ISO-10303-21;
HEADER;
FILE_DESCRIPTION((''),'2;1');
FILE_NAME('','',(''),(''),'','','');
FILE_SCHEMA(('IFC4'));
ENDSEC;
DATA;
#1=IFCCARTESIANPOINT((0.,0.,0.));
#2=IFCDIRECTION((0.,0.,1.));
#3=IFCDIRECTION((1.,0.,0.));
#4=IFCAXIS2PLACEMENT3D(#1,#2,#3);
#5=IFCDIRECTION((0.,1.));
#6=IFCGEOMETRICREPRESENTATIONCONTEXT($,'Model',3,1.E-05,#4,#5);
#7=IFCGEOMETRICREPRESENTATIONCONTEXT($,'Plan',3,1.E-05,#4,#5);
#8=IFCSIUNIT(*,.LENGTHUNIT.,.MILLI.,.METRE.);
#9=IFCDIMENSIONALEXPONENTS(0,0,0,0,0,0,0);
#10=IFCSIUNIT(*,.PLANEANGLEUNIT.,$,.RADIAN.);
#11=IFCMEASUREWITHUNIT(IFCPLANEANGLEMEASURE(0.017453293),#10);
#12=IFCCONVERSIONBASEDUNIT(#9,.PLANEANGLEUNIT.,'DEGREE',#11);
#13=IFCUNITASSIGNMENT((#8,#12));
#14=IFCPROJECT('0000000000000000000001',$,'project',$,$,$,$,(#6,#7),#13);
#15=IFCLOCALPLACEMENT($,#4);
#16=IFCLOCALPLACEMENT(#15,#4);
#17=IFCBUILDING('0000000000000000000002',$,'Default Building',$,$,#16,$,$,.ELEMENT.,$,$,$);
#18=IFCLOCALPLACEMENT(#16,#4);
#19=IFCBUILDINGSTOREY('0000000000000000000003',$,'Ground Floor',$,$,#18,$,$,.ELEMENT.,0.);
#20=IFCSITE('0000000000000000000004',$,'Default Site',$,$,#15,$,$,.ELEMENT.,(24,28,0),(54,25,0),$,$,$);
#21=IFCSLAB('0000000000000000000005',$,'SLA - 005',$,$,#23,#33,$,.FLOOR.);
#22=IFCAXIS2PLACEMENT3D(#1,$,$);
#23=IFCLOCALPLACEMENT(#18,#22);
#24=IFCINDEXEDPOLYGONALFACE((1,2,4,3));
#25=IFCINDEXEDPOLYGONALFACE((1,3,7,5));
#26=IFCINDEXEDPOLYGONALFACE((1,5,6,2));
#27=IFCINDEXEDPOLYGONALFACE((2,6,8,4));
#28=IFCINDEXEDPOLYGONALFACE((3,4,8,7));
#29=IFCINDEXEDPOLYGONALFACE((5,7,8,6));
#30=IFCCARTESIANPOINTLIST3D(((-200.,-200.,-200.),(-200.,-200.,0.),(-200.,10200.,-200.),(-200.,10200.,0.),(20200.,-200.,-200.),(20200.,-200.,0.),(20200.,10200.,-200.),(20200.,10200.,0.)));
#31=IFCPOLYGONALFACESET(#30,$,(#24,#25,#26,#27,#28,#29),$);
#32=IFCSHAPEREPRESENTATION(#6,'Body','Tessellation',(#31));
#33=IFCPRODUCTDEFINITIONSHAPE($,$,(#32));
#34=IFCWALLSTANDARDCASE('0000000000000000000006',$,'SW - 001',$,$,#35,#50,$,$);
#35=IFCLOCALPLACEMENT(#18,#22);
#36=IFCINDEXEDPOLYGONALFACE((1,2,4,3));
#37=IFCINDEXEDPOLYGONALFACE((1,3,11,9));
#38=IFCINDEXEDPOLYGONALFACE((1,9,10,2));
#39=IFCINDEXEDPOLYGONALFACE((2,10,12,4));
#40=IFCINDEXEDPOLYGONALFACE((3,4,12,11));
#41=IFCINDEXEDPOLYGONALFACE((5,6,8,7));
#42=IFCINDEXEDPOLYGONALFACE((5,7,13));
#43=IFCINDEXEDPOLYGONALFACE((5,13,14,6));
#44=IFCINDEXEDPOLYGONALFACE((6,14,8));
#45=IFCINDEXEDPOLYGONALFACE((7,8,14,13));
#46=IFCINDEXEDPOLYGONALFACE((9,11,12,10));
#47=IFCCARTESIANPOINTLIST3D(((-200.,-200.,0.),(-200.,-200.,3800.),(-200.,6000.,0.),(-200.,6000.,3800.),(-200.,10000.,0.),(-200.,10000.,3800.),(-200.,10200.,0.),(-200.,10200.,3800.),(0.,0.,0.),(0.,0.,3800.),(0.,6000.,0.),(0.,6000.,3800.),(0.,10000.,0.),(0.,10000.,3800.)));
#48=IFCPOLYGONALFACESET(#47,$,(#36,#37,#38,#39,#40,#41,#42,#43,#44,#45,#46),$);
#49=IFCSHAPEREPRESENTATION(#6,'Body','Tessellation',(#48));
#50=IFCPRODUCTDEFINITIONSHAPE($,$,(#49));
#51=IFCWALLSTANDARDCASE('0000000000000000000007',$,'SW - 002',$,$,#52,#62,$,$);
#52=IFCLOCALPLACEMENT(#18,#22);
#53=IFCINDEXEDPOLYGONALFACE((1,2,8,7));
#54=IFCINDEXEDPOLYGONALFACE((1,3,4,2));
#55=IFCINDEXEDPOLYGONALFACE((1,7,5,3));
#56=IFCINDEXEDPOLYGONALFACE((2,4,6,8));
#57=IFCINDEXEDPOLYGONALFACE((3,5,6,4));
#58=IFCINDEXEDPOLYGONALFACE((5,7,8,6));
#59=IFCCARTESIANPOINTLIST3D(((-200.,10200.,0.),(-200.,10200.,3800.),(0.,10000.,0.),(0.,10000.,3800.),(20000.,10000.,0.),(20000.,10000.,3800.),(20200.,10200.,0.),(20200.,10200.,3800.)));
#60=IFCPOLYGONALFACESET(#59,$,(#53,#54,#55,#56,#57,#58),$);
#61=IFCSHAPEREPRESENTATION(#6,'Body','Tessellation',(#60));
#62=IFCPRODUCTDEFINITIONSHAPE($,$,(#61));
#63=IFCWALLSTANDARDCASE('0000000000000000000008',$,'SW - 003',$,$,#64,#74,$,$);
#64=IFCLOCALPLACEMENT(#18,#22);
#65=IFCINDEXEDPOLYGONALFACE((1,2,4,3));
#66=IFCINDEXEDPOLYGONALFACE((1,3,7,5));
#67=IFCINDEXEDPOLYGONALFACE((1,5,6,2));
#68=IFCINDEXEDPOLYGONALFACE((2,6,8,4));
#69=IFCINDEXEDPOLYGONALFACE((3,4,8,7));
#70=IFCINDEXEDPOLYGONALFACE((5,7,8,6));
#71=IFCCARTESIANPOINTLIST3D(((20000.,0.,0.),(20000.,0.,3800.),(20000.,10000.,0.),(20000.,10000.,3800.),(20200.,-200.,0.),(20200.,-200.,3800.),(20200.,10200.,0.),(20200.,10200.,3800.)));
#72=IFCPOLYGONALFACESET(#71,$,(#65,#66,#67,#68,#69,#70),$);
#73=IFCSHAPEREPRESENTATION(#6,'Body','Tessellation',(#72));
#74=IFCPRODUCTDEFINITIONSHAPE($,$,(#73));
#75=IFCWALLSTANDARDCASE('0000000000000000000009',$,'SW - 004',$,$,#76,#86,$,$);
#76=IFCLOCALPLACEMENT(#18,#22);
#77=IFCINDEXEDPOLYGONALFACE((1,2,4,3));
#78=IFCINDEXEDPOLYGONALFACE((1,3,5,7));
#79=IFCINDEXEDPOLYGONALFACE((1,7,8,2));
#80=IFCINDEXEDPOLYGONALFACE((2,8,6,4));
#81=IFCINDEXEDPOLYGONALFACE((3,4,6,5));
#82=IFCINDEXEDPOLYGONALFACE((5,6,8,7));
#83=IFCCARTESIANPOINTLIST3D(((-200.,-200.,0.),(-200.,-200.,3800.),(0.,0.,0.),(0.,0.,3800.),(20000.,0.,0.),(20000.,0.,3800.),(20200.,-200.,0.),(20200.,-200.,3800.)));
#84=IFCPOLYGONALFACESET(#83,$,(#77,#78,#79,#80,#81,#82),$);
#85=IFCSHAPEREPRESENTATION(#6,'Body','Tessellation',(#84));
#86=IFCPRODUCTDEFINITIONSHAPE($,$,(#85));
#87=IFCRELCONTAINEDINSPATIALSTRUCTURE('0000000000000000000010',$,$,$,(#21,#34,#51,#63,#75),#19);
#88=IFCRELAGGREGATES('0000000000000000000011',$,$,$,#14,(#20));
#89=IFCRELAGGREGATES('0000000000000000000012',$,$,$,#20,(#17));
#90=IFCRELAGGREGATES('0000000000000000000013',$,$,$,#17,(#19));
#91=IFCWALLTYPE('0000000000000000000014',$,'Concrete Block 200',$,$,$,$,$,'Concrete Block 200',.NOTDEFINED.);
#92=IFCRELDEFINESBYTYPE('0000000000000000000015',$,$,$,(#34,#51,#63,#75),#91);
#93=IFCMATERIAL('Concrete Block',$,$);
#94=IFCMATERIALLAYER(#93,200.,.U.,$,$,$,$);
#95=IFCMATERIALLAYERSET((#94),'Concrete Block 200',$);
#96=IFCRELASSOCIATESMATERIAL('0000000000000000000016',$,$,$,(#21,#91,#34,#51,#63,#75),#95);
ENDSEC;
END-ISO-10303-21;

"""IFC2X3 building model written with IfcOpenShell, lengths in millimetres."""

from ifc_helpers import new_model, entity, si_unit, converted_unit, direction, frame, origin_with_axes, place, context, project, spatial, polyline, outline, extrude, material, layer, layer_set, layer_usage, type_object, element, save


model = new_model("IFC2X3")

# Units and contexts
model_context = context("Model", 3, precision=1e-05, world=origin_with_axes(), true_north=direction((0.0, 1.0)))
plan_context = context("Plan", 3, precision=1e-05, world=origin_with_axes(), true_north=direction((0.0, 1.0)))
ifc_project = project(units=[si_unit("LENGTHUNIT", "METRE", prefix="MILLI"), converted_unit("PLANEANGLEUNIT", "DEGREE", entity("IfcPlaneAngleMeasure", 0.017453293), si_unit("PLANEANGLEUNIT", "RADIAN"), dimensions=[0, 0, 0, 0, 0, 0, 0])], contexts=[model_context, plan_context])

# Site, building, storey
site_placement = place(None, origin_with_axes())
site = spatial("IfcSite", under=ifc_project, at=site_placement, Name="Default Site", CompositionType="ELEMENT", RefLatitude=(24, 28, 0), RefLongitude=(54, 25, 0))
building_placement = place(site_placement, origin_with_axes())
building = spatial("IfcBuilding", under=site, at=building_placement, Name="Default Building", CompositionType="ELEMENT")
storey_placement = place(building_placement, origin_with_axes())
storey = spatial("IfcBuildingStorey", under=building, at=storey_placement, Name="Ground Floor", CompositionType="ELEMENT", Elevation=0.0)

# Slab
ifc_material = material(Name="Concrete Block")
ifc_layer = layer(ifc_material, 200.0, ventilated="UNKNOWN")
ifc_layer_set = layer_set([ifc_layer], Name="Concrete Block 200")
ifc_layer_usage_1 = layer_usage(ifc_layer_set, "AXIS3", "NEGATIVE", 200.0)
slab_placement = place(storey_placement, frame((-200.0, 10200.0, -200.0), z_axis=(0.0, 0.0, 1.0), x_axis=(1.0, 0.0, 0.0)))
element("IfcSlab", 1, at=slab_placement, inside=storey, material=ifc_layer_usage_1, Name="SLA - 005", PredefinedType="FLOOR", context=model_context, shape_type="SweptSolid", body=[
    extrude(outline(polyline([(0.0, 0.0), (20400.0, 0.0), (20400.0, -10400.0), (0.0, -10400.0), (0.0, 0.0)])), origin_with_axes(), (0.0, 0.0, 1.0), 200.0),
])

# Wall, opening
ifc_layer_usage_2 = layer_usage(ifc_layer_set, "AXIS2", "POSITIVE", 0.0)
wall_type = type_object("IfcWallType", Name="Concrete Block 200", ElementType="Concrete Block 200", PredefinedType="NOTDEFINED", material=ifc_layer_set)
wall_1_placement = place(storey_placement, frame((0.0, 0.0, 0.0), z_axis=(0.0, 0.0, 1.0), x_axis=(0.0, 1.0, 0.0)))
wall_1 = element("IfcWallStandardCase", 2, at=wall_1_placement, inside=storey, type_object=wall_type, material=ifc_layer_usage_2, Name="SW - 001", context=model_context, shape_type="SweptSolid", body=[
    extrude(outline(polyline([(0.0, 0.0), (10000.0, 0.0), (10200.0, 200.0), (-200.0, 200.0), (0.0, 0.0)])), origin_with_axes(), (0.0, 0.0, 1.0), 3800.0),
])
opening_placement = place(wall_1_placement, frame((8000.0, 0.0, 0.0), z_axis=(0.0, 0.0, 1.0), x_axis=(1.0, 0.0, 0.0)))
element("IfcOpeningElement", 3, at=opening_placement, cuts=wall_1, ObjectType="Opening", context=model_context, shape_type="SweptSolid", body=[
    extrude(outline(polyline([(-2000.0, 0.0), (2000.0, 0.0), (2000.0, 3800.0), (-2000.0, 3800.0), (-2000.0, 0.0)])), frame((0.0, 0.0, 0.0), z_axis=(0.0, 1.0, 0.0), x_axis=(-1.0, 0.0, 0.0)), (0.0, 0.0, 1.0), 200.0),
])

# Walls
ifc_layer_usage_3 = layer_usage(ifc_layer_set, "AXIS2", "POSITIVE", 0.0)
wall_2_placement = place(storey_placement, frame((0.0, 10000.0, 0.0), z_axis=(0.0, 0.0, 1.0), x_axis=(1.0, 0.0, 0.0)))
element("IfcWallStandardCase", 4, at=wall_2_placement, inside=storey, type_object=wall_type, material=ifc_layer_usage_3, Name="SW - 002", context=model_context, shape_type="SweptSolid", body=[
    extrude(outline(polyline([(0.0, 0.0), (20000.0, 0.0), (20200.0, 200.0), (-200.0, 200.0), (0.0, 0.0)])), origin_with_axes(), (0.0, 0.0, 1.0), 3800.0),
])
ifc_layer_usage_4 = layer_usage(ifc_layer_set, "AXIS2", "POSITIVE", 0.0)
wall_3_placement = place(storey_placement, frame((20000.0, 10000.0, 0.0), z_axis=(0.0, 0.0, 1.0), x_axis=(0.0, -1.0, 0.0)))
element("IfcWallStandardCase", 5, at=wall_3_placement, inside=storey, type_object=wall_type, material=ifc_layer_usage_4, Name="SW - 003", context=model_context, shape_type="SweptSolid", body=[
    extrude(outline(polyline([(0.0, 0.0), (10000.0, 0.0), (10200.0, 200.0), (-200.0, 200.0), (0.0, 0.0)])), origin_with_axes(), (0.0, 0.0, 1.0), 3800.0),
])
ifc_layer_usage_5 = layer_usage(ifc_layer_set, "AXIS2", "POSITIVE", 0.0)
wall_4_placement = place(storey_placement, frame((20000.0, 0.0, 0.0), z_axis=(0.0, 0.0, 1.0), x_axis=(-1.0, 0.0, 0.0)))
element("IfcWallStandardCase", 6, at=wall_4_placement, inside=storey, type_object=wall_type, material=ifc_layer_usage_5, Name="SW - 004", context=model_context, shape_type="SweptSolid", body=[
    extrude(outline(polyline([(0.0, 0.0), (20000.0, 0.0), (20200.0, 200.0), (-200.0, 200.0), (0.0, 0.0)])), origin_with_axes(), (0.0, 0.0, 1.0), 3800.0),
])

save(model, "model.ifc")
